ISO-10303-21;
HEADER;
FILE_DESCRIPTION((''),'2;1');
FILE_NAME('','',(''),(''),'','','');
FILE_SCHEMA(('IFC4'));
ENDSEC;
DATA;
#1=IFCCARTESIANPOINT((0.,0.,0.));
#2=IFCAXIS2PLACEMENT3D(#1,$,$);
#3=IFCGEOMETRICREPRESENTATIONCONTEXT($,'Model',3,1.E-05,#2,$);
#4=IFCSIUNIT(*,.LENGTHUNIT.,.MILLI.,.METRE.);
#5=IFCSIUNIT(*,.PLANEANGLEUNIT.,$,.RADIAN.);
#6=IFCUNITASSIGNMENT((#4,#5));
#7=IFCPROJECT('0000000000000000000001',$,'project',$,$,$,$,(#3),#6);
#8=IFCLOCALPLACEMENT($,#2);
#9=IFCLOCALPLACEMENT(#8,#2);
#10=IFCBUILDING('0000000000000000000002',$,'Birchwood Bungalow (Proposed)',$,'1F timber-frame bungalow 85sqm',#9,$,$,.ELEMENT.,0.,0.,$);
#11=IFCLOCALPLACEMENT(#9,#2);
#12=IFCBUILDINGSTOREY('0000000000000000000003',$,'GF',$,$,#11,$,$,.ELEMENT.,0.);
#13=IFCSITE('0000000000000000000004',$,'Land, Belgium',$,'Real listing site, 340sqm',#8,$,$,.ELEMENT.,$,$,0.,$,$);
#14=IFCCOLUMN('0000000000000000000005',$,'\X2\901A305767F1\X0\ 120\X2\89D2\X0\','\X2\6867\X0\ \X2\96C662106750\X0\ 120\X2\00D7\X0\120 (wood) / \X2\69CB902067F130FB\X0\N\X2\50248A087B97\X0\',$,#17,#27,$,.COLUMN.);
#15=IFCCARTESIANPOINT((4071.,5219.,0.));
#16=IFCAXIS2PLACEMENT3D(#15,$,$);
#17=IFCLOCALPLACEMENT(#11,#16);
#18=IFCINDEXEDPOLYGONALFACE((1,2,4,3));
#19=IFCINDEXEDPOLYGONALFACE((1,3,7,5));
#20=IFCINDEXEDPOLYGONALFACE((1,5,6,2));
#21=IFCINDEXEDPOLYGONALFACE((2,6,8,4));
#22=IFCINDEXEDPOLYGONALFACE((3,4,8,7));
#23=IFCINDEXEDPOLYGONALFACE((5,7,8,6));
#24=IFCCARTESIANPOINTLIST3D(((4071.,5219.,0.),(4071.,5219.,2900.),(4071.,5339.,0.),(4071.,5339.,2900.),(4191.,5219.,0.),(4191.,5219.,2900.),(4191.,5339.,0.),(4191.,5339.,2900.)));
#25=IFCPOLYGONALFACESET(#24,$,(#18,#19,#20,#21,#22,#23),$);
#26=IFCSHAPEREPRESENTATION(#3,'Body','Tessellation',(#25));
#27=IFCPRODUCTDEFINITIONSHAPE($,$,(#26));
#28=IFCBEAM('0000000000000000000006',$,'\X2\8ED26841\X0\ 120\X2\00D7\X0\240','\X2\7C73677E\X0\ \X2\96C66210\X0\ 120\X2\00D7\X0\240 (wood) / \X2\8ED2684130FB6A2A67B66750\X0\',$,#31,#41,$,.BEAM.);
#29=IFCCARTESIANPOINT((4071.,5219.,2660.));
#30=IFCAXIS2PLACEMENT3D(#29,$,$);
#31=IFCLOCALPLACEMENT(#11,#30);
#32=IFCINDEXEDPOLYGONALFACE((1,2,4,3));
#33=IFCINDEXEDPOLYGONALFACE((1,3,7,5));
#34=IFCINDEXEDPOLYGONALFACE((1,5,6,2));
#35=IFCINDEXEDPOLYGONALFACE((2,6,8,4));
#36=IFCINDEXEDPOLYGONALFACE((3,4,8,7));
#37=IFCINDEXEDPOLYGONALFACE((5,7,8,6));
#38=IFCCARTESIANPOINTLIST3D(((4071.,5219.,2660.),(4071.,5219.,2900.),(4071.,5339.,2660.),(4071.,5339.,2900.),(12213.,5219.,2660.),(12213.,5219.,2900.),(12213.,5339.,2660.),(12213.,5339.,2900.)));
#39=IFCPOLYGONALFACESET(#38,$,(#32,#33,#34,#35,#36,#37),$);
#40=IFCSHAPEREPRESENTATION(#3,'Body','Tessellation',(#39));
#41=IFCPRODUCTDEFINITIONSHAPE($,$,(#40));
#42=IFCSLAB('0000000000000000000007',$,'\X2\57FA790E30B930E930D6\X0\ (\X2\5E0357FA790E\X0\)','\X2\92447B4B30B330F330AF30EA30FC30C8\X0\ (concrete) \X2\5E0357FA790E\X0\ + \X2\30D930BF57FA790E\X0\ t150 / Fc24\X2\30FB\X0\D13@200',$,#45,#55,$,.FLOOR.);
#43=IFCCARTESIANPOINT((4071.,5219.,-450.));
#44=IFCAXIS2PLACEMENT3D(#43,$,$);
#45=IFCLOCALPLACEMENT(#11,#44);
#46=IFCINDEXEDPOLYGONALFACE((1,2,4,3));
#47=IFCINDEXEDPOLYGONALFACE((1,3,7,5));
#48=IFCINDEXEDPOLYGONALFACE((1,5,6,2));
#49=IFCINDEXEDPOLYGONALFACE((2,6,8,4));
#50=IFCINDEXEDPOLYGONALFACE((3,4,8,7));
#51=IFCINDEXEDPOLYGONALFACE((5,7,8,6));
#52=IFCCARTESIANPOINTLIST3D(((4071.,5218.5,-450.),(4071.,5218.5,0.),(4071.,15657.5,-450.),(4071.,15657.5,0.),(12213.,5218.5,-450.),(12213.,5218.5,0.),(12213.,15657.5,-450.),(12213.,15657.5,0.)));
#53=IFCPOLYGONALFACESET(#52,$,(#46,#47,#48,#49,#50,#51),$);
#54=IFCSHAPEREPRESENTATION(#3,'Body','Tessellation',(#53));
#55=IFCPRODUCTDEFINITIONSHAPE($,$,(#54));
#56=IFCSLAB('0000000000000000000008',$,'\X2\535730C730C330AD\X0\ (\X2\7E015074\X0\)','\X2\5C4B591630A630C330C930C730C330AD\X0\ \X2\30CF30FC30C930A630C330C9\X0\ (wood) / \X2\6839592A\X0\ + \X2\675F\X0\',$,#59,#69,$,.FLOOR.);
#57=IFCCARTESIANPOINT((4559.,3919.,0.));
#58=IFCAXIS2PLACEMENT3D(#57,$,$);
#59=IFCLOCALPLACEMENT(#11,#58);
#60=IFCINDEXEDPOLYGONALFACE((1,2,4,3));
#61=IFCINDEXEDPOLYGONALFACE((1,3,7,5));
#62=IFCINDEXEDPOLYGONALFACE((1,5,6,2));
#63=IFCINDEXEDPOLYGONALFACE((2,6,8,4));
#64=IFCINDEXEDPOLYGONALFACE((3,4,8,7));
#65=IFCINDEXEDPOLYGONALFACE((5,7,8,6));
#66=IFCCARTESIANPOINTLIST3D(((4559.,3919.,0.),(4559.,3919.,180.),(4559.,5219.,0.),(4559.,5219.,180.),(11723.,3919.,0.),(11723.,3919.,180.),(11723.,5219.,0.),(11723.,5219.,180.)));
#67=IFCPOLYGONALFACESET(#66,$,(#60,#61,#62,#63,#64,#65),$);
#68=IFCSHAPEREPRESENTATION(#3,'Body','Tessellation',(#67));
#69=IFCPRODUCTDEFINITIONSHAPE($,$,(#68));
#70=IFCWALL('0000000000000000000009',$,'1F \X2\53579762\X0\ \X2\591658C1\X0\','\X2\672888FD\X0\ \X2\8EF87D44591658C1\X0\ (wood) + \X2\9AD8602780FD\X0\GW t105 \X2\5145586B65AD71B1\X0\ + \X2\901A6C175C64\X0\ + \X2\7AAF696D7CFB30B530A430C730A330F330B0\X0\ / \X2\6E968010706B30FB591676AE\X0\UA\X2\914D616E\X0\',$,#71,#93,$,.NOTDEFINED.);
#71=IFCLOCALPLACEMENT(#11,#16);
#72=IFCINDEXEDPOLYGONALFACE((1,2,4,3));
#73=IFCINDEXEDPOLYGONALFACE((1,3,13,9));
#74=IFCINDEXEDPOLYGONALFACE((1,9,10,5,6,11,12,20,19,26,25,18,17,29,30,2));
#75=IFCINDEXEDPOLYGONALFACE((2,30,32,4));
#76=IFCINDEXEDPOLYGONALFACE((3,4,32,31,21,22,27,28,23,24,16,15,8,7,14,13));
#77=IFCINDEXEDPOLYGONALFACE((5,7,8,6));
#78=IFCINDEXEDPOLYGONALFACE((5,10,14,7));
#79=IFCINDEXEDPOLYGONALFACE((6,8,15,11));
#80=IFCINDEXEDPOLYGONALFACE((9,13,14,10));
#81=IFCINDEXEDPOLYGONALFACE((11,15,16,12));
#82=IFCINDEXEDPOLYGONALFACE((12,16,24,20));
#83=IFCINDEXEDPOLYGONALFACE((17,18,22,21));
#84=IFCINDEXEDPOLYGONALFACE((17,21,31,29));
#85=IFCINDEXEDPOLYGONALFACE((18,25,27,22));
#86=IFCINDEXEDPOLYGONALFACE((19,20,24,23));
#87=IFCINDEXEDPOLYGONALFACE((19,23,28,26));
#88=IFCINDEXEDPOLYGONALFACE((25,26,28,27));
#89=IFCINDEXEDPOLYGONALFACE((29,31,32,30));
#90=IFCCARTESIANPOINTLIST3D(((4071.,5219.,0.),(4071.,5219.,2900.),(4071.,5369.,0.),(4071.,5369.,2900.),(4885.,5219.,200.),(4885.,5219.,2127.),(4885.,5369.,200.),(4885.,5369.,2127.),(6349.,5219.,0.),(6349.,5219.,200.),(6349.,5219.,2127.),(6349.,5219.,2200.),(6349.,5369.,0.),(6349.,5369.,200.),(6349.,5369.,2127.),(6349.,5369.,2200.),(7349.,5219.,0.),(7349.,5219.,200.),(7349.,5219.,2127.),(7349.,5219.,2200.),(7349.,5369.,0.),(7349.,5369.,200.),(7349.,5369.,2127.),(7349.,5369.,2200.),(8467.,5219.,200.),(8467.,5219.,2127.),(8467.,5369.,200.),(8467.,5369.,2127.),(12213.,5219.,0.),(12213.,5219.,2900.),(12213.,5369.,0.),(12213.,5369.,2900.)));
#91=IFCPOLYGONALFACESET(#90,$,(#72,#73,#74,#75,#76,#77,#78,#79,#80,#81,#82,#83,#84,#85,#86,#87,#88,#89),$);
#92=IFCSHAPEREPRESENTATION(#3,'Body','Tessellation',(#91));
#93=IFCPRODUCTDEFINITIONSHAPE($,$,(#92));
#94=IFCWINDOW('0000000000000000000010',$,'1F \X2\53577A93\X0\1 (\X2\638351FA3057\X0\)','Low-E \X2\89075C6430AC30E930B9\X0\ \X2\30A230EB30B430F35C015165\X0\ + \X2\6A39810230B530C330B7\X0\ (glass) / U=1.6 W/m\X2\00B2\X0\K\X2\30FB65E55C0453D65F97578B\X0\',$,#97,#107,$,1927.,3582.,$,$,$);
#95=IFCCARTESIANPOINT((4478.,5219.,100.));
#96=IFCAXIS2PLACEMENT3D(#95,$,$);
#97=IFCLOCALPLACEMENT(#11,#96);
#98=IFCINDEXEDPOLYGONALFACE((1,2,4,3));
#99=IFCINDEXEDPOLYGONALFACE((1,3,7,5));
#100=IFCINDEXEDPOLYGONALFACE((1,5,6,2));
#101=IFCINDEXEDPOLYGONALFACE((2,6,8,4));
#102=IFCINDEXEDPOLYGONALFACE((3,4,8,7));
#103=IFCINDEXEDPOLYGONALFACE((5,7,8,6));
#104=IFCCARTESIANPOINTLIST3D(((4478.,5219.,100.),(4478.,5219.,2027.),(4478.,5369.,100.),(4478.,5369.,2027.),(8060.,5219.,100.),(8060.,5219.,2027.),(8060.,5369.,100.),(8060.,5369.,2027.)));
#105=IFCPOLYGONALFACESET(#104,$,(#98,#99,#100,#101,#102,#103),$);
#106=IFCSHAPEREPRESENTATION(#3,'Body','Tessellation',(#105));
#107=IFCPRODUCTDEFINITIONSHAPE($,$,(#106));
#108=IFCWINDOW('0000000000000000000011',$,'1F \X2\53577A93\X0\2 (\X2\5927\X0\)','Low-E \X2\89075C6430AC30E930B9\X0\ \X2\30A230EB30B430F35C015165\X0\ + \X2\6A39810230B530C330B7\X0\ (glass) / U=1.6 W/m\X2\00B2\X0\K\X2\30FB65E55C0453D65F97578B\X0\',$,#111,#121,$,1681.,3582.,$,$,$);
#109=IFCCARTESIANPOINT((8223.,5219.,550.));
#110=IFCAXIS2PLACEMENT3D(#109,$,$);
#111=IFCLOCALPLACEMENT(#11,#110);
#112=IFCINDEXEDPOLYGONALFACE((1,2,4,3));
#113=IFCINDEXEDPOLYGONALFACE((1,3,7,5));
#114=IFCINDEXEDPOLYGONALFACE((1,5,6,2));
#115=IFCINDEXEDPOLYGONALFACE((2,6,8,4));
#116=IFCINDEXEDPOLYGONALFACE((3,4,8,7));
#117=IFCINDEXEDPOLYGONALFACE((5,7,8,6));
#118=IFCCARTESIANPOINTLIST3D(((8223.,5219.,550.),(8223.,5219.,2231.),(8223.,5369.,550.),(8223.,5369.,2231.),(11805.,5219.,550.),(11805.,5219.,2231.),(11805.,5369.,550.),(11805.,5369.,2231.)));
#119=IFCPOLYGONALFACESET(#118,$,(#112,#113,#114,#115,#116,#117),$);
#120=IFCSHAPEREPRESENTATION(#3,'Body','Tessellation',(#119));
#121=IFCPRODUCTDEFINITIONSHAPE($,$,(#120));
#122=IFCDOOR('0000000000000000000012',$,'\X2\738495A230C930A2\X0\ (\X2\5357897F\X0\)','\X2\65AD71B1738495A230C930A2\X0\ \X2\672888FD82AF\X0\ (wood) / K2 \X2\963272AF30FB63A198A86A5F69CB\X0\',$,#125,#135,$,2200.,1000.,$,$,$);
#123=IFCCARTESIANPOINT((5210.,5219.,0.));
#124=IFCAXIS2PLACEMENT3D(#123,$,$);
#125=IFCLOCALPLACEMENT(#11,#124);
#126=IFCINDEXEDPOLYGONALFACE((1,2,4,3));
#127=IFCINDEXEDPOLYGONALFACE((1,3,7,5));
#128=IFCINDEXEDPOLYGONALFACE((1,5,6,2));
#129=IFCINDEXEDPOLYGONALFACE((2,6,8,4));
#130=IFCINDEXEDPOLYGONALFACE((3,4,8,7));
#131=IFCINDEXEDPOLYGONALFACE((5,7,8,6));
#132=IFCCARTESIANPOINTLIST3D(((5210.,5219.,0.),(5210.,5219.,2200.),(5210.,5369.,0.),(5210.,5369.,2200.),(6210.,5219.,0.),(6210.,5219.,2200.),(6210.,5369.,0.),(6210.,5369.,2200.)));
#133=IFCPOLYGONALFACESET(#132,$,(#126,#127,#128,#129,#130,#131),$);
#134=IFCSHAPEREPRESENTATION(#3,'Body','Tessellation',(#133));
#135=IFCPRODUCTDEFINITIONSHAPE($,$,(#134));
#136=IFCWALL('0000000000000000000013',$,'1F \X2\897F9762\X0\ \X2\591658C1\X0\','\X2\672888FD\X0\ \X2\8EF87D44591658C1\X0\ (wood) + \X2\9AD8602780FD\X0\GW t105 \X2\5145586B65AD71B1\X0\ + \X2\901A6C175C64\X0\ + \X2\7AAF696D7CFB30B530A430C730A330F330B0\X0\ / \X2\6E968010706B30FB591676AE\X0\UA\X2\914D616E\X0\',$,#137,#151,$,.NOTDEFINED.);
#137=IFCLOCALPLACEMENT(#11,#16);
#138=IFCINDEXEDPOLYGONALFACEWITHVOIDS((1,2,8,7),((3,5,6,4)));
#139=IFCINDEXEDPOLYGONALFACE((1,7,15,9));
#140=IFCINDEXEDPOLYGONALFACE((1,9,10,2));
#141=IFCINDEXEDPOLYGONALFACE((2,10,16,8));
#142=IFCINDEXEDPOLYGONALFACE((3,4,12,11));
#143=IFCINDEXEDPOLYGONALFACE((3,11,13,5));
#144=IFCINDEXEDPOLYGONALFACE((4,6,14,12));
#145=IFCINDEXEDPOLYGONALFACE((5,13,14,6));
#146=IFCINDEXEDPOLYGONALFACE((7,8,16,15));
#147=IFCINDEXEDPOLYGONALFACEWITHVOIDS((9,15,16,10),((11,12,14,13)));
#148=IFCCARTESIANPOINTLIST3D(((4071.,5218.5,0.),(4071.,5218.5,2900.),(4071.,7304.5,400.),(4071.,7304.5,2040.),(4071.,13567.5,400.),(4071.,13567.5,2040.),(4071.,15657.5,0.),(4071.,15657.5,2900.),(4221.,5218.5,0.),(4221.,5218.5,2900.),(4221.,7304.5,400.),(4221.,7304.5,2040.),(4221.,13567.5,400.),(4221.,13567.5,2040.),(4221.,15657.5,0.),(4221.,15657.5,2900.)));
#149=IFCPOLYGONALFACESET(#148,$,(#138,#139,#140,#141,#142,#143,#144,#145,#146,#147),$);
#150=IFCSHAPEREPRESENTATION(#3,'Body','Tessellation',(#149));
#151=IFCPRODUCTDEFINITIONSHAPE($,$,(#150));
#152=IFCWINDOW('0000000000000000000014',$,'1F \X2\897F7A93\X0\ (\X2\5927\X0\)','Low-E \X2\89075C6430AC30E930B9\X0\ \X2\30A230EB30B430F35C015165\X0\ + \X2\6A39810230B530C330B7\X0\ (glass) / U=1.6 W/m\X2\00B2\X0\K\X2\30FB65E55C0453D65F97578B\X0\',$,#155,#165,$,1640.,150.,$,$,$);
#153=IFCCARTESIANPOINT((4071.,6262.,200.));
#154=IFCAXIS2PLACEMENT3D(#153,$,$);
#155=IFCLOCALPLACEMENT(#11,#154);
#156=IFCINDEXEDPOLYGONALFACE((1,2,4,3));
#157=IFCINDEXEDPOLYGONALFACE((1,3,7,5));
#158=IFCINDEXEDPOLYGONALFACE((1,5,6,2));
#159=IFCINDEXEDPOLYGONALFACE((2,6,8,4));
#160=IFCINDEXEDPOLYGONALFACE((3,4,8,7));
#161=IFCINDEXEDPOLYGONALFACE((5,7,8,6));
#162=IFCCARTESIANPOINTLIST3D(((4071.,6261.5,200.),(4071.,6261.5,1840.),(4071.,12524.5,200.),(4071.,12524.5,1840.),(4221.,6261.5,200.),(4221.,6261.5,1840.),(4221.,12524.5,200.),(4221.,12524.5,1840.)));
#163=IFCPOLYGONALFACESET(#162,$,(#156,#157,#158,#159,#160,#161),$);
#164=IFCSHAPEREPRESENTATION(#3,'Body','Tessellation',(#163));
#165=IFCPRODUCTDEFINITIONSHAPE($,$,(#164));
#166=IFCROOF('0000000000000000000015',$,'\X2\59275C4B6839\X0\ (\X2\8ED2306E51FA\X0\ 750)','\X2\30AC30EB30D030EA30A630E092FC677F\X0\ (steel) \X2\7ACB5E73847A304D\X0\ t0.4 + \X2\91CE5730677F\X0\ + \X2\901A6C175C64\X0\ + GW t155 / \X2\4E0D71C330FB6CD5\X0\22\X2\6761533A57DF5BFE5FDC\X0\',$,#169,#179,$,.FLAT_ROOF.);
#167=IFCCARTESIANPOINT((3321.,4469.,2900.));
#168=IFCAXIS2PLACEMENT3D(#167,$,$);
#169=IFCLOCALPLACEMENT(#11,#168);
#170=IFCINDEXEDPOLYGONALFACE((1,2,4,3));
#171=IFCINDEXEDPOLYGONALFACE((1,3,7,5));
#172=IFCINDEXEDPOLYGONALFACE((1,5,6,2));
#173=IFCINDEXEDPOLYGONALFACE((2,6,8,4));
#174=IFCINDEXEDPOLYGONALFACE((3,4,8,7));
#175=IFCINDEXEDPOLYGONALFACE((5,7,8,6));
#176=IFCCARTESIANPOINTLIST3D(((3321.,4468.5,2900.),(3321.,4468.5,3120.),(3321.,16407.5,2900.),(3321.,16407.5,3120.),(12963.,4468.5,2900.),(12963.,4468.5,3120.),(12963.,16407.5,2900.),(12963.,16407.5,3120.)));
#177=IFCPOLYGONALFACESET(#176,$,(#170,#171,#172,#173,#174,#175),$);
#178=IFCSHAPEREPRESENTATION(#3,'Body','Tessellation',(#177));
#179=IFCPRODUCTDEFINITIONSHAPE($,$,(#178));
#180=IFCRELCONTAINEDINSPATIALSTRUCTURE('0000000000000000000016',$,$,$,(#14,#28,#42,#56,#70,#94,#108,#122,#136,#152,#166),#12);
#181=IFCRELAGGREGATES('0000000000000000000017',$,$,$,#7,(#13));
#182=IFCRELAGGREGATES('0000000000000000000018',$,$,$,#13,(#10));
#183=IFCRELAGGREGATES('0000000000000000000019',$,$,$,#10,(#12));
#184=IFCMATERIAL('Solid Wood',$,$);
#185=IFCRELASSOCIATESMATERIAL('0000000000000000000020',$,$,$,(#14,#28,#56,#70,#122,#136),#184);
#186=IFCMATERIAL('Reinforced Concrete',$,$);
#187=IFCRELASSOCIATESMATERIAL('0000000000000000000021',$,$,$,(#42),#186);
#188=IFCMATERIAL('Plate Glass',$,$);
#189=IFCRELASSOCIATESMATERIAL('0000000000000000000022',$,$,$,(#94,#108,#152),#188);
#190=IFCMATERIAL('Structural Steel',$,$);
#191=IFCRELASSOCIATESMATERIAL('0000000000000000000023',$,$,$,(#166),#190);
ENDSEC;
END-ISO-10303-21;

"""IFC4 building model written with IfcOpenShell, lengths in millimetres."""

from ifc_helpers import new_model, si_unit, frame, frame_2d, origin, place, context, project, spatial, rectangle, extrude, material, element, fill, save


model = new_model("IFC4")

# Units and contexts
model_context = context("Model", 3, precision=1e-05, world=origin())
ifc_project = project(units=[si_unit("LENGTHUNIT", "METRE", prefix="MILLI"), si_unit("PLANEANGLEUNIT", "RADIAN")], contexts=[model_context])

# Site, building, storey
site_placement = place(None, origin())
site = spatial("IfcSite", under=ifc_project, at=site_placement, Name="Land, Belgium", ObjectType="Real listing site, 340sqm", CompositionType="ELEMENT", RefElevation=0.0)
building_placement = place(site_placement, origin())
building = spatial("IfcBuilding", under=site, at=building_placement, Name="Birchwood Bungalow (Proposed)", ObjectType="1F timber-frame bungalow 85sqm", CompositionType="ELEMENT", ElevationOfRefHeight=0.0, ElevationOfTerrain=0.0)
storey_placement = place(building_placement, origin())
storey = spatial("IfcBuildingStorey", under=building, at=storey_placement, Name="GF", CompositionType="ELEMENT", Elevation=0.0)

# Column
ifc_material_1 = material(Name="Solid Wood")
column_1_placement = place(storey_placement, frame((4071.0, 5219.0, 0.0)))
element("IfcColumn", 1, at=column_1_placement, inside=storey, material=ifc_material_1, Name="通し柱 120角", Description="桧 集成材 120×120 (wood) / 構造柱・N値計算", PredefinedType="COLUMN", context=model_context, shape_type="SweptSolid", body=[
    extrude(rectangle(XDim=120.0, YDim=120.0, at=frame_2d((60.0, 60.0))), frame((4071.0, 5219.0, 0.0)), (0.0, 0.0, 1.0), 2900.0),
])

# Beam
beam_1_placement = place(storey_placement, frame((4071.0, 5219.0, 2660.0)))
element("IfcBeam", 2, at=beam_1_placement, inside=storey, material=ifc_material_1, Name="軒桁 120×240", Description="米松 集成 120×240 (wood) / 軒桁・横架材", PredefinedType="BEAM", context=model_context, shape_type="SweptSolid", body=[
    extrude(rectangle(XDim=8142.0, YDim=120.0, at=frame_2d((4071.0, 60.0))), frame((4071.0, 5219.0, 2660.0)), (0.0, 0.0, 1.0), 240.0),
])

# Slabs
ifc_material_2 = material(Name="Reinforced Concrete")
slab_1_placement = place(storey_placement, frame((4071.0, 5219.0, -450.0)))
element("IfcSlab", 3, at=slab_1_placement, inside=storey, material=ifc_material_2, Name="基礎スラブ (布基礎)", Description="鉄筋コンクリート (concrete) 布基礎 + ベタ基礎 t150 / Fc24・D13@200", PredefinedType="FLOOR", context=model_context, shape_type="SweptSolid", body=[
    extrude(rectangle(XDim=8142.0, YDim=10439.0, at=frame_2d((4071.0, 5219.0))), frame((4071.0, 5219.0, -450.0)), (0.0, 0.0, 1.0), 450.0),
])
slab_2_placement = place(storey_placement, frame((4559.0, 3919.0, 0.0)))
element("IfcSlab", 4, at=slab_2_placement, inside=storey, material=ifc_material_1, Name="南デッキ (縁側)", Description="屋外ウッドデッキ ハードウッド (wood) / 根太 + 束", PredefinedType="FLOOR", context=model_context, shape_type="SweptSolid", body=[
    extrude(rectangle(XDim=7164.0, YDim=1300.0, at=frame_2d((3582.0, 650.0))), frame((4559.0, 3919.0, 0.0)), (0.0, 0.0, 1.0), 180.0),
])

# Wall, openings, windows, door
wall_1_placement = place(storey_placement, frame((4071.0, 5219.0, 0.0)))
wall_1 = element("IfcWall", 5, at=wall_1_placement, inside=storey, material=ifc_material_1, Name="1F 南面 外壁", Description="木製 軸組外壁 (wood) + 高性能GW t105 充填断熱 + 通気層 + 窯業系サイディング / 準耐火・外皮UA配慮", PredefinedType="NOTDEFINED", context=model_context, shape_type="SweptSolid", body=[
    extrude(rectangle(XDim=8142.0, YDim=150.0, at=frame_2d((4071.0, 75.0))), frame((4071.0, 5219.0, 0.0)), (0.0, 0.0, 1.0), 2900.0),
])
opening_1_placement = place(storey_placement, frame((4478.0, 5219.0, 100.0)))
opening_1 = element("IfcOpeningElement", 6, at=opening_1_placement, cuts=wall_1, PredefinedType="NOTDEFINED", context=model_context, shape_type="SweptSolid", body=[
    extrude(rectangle(XDim=3582.0, YDim=150.0, at=frame_2d((1791.0, 75.0))), frame((4478.0, 5219.0, 100.0)), (0.0, 0.0, 1.0), 1927.0),
])
opening_2_placement = place(storey_placement, frame((8223.0, 5219.0, 550.0)))
opening_2 = element("IfcOpeningElement", 7, at=opening_2_placement, cuts=wall_1, PredefinedType="NOTDEFINED", context=model_context, shape_type="SweptSolid", body=[
    extrude(rectangle(XDim=3582.0, YDim=150.0, at=frame_2d((1791.0, 75.0))), frame((8223.0, 5219.0, 550.0)), (0.0, 0.0, 1.0), 1681.0),
])
opening_3_placement = place(storey_placement, frame((5210.0, 5219.0, 0.0)))
opening_3 = element("IfcOpeningElement", 8, at=opening_3_placement, cuts=wall_1, PredefinedType="NOTDEFINED", context=model_context, shape_type="SweptSolid", body=[
    extrude(rectangle(XDim=1000.0, YDim=150.0, at=frame_2d((500.0, 75.0))), frame((5210.0, 5219.0, 0.0)), (0.0, 0.0, 1.0), 2200.0),
])
ifc_material_3 = material(Name="Plate Glass")
window_1_placement = place(storey_placement, frame((4478.0, 5219.0, 100.0)))
window_1 = element("IfcWindow", 9, at=window_1_placement, inside=storey, material=ifc_material_3, Name="1F 南窓1 (掃出し)", Description="Low-E 複層ガラス アルゴン封入 + 樹脂サッシ (glass) / U=1.6 W/m²K・日射取得型", OverallHeight=1927.0, OverallWidth=3582.0, context=model_context, shape_type="SweptSolid", body=[
    extrude(rectangle(XDim=3582.0, YDim=150.0, at=frame_2d((1791.0, 75.0))), frame((4478.0, 5219.0, 100.0)), (0.0, 0.0, 1.0), 1927.0),
])
fill(opening_1, window_1)
window_2_placement = place(storey_placement, frame((8223.0, 5219.0, 550.0)))
window_2 = element("IfcWindow", 10, at=window_2_placement, inside=storey, material=ifc_material_3, Name="1F 南窓2 (大)", Description="Low-E 複層ガラス アルゴン封入 + 樹脂サッシ (glass) / U=1.6 W/m²K・日射取得型", OverallHeight=1681.0, OverallWidth=3582.0, context=model_context, shape_type="SweptSolid", body=[
    extrude(rectangle(XDim=3582.0, YDim=150.0, at=frame_2d((1791.0, 75.0))), frame((8223.0, 5219.0, 550.0)), (0.0, 0.0, 1.0), 1681.0),
])
fill(opening_2, window_2)
door_placement = place(storey_placement, frame((5210.0, 5219.0, 0.0)))
door = element("IfcDoor", 11, at=door_placement, inside=storey, material=ifc_material_1, Name="玄関ドア (南西)", Description="断熱玄関ドア 木製芯 (wood) / K2 防犯・採風機構", OverallHeight=2200.0, OverallWidth=1000.0, context=model_context, shape_type="SweptSolid", body=[
    extrude(rectangle(XDim=1000.0, YDim=150.0, at=frame_2d((500.0, 75.0))), frame((5210.0, 5219.0, 0.0)), (0.0, 0.0, 1.0), 2200.0),
])
fill(opening_3, door)

# Wall, opening, window
wall_2_placement = place(storey_placement, frame((4071.0, 5219.0, 0.0)))
wall_2 = element("IfcWall", 12, at=wall_2_placement, inside=storey, material=ifc_material_1, Name="1F 西面 外壁", Description="木製 軸組外壁 (wood) + 高性能GW t105 充填断熱 + 通気層 + 窯業系サイディング / 準耐火・外皮UA配慮", PredefinedType="NOTDEFINED", context=model_context, shape_type="SweptSolid", body=[
    extrude(rectangle(XDim=150.0, YDim=10439.0, at=frame_2d((75.0, 5219.0))), frame((4071.0, 5219.0, 0.0)), (0.0, 0.0, 1.0), 2900.0),
])
opening_4_placement = place(storey_placement, frame((4071.0, 6262.0, 200.0)))
opening_4 = element("IfcOpeningElement", 13, at=opening_4_placement, cuts=wall_2, PredefinedType="NOTDEFINED", context=model_context, shape_type="SweptSolid", body=[
    extrude(rectangle(XDim=150.0, YDim=6263.0, at=frame_2d((75.0, 3131.0))), frame((4071.0, 6262.0, 200.0)), (0.0, 0.0, 1.0), 1640.0),
])
window_3_placement = place(storey_placement, frame((4071.0, 6262.0, 200.0)))
window_3 = element("IfcWindow", 14, at=window_3_placement, inside=storey, material=ifc_material_3, Name="1F 西窓 (大)", Description="Low-E 複層ガラス アルゴン封入 + 樹脂サッシ (glass) / U=1.6 W/m²K・日射取得型", OverallHeight=1640.0, OverallWidth=150.0, context=model_context, shape_type="SweptSolid", body=[
    extrude(rectangle(XDim=150.0, YDim=6263.0, at=frame_2d((75.0, 3131.0))), frame((4071.0, 6262.0, 200.0)), (0.0, 0.0, 1.0), 1640.0),
])
fill(opening_4, window_3)

# Roof
ifc_material_4 = material(Name="Structural Steel")
roof_placement = place(storey_placement, frame((3321.0, 4469.0, 2900.0)))
element("IfcRoof", 15, at=roof_placement, inside=storey, material=ifc_material_4, Name="大屋根 (軒の出 750)", Description="ガルバリウム鋼板 (steel) 立平葺き t0.4 + 野地板 + 通気層 + GW t155 / 不燃・法22条区域対応", PredefinedType="FLAT_ROOF", context=model_context, shape_type="SweptSolid", body=[
    extrude(rectangle(XDim=9642.0, YDim=11939.0, at=frame_2d((4821.0, 5969.0))), frame((3321.0, 4469.0, 2900.0)), (0.0, 0.0, 1.0), 220.0),
])

save(model, "model.ifc")
